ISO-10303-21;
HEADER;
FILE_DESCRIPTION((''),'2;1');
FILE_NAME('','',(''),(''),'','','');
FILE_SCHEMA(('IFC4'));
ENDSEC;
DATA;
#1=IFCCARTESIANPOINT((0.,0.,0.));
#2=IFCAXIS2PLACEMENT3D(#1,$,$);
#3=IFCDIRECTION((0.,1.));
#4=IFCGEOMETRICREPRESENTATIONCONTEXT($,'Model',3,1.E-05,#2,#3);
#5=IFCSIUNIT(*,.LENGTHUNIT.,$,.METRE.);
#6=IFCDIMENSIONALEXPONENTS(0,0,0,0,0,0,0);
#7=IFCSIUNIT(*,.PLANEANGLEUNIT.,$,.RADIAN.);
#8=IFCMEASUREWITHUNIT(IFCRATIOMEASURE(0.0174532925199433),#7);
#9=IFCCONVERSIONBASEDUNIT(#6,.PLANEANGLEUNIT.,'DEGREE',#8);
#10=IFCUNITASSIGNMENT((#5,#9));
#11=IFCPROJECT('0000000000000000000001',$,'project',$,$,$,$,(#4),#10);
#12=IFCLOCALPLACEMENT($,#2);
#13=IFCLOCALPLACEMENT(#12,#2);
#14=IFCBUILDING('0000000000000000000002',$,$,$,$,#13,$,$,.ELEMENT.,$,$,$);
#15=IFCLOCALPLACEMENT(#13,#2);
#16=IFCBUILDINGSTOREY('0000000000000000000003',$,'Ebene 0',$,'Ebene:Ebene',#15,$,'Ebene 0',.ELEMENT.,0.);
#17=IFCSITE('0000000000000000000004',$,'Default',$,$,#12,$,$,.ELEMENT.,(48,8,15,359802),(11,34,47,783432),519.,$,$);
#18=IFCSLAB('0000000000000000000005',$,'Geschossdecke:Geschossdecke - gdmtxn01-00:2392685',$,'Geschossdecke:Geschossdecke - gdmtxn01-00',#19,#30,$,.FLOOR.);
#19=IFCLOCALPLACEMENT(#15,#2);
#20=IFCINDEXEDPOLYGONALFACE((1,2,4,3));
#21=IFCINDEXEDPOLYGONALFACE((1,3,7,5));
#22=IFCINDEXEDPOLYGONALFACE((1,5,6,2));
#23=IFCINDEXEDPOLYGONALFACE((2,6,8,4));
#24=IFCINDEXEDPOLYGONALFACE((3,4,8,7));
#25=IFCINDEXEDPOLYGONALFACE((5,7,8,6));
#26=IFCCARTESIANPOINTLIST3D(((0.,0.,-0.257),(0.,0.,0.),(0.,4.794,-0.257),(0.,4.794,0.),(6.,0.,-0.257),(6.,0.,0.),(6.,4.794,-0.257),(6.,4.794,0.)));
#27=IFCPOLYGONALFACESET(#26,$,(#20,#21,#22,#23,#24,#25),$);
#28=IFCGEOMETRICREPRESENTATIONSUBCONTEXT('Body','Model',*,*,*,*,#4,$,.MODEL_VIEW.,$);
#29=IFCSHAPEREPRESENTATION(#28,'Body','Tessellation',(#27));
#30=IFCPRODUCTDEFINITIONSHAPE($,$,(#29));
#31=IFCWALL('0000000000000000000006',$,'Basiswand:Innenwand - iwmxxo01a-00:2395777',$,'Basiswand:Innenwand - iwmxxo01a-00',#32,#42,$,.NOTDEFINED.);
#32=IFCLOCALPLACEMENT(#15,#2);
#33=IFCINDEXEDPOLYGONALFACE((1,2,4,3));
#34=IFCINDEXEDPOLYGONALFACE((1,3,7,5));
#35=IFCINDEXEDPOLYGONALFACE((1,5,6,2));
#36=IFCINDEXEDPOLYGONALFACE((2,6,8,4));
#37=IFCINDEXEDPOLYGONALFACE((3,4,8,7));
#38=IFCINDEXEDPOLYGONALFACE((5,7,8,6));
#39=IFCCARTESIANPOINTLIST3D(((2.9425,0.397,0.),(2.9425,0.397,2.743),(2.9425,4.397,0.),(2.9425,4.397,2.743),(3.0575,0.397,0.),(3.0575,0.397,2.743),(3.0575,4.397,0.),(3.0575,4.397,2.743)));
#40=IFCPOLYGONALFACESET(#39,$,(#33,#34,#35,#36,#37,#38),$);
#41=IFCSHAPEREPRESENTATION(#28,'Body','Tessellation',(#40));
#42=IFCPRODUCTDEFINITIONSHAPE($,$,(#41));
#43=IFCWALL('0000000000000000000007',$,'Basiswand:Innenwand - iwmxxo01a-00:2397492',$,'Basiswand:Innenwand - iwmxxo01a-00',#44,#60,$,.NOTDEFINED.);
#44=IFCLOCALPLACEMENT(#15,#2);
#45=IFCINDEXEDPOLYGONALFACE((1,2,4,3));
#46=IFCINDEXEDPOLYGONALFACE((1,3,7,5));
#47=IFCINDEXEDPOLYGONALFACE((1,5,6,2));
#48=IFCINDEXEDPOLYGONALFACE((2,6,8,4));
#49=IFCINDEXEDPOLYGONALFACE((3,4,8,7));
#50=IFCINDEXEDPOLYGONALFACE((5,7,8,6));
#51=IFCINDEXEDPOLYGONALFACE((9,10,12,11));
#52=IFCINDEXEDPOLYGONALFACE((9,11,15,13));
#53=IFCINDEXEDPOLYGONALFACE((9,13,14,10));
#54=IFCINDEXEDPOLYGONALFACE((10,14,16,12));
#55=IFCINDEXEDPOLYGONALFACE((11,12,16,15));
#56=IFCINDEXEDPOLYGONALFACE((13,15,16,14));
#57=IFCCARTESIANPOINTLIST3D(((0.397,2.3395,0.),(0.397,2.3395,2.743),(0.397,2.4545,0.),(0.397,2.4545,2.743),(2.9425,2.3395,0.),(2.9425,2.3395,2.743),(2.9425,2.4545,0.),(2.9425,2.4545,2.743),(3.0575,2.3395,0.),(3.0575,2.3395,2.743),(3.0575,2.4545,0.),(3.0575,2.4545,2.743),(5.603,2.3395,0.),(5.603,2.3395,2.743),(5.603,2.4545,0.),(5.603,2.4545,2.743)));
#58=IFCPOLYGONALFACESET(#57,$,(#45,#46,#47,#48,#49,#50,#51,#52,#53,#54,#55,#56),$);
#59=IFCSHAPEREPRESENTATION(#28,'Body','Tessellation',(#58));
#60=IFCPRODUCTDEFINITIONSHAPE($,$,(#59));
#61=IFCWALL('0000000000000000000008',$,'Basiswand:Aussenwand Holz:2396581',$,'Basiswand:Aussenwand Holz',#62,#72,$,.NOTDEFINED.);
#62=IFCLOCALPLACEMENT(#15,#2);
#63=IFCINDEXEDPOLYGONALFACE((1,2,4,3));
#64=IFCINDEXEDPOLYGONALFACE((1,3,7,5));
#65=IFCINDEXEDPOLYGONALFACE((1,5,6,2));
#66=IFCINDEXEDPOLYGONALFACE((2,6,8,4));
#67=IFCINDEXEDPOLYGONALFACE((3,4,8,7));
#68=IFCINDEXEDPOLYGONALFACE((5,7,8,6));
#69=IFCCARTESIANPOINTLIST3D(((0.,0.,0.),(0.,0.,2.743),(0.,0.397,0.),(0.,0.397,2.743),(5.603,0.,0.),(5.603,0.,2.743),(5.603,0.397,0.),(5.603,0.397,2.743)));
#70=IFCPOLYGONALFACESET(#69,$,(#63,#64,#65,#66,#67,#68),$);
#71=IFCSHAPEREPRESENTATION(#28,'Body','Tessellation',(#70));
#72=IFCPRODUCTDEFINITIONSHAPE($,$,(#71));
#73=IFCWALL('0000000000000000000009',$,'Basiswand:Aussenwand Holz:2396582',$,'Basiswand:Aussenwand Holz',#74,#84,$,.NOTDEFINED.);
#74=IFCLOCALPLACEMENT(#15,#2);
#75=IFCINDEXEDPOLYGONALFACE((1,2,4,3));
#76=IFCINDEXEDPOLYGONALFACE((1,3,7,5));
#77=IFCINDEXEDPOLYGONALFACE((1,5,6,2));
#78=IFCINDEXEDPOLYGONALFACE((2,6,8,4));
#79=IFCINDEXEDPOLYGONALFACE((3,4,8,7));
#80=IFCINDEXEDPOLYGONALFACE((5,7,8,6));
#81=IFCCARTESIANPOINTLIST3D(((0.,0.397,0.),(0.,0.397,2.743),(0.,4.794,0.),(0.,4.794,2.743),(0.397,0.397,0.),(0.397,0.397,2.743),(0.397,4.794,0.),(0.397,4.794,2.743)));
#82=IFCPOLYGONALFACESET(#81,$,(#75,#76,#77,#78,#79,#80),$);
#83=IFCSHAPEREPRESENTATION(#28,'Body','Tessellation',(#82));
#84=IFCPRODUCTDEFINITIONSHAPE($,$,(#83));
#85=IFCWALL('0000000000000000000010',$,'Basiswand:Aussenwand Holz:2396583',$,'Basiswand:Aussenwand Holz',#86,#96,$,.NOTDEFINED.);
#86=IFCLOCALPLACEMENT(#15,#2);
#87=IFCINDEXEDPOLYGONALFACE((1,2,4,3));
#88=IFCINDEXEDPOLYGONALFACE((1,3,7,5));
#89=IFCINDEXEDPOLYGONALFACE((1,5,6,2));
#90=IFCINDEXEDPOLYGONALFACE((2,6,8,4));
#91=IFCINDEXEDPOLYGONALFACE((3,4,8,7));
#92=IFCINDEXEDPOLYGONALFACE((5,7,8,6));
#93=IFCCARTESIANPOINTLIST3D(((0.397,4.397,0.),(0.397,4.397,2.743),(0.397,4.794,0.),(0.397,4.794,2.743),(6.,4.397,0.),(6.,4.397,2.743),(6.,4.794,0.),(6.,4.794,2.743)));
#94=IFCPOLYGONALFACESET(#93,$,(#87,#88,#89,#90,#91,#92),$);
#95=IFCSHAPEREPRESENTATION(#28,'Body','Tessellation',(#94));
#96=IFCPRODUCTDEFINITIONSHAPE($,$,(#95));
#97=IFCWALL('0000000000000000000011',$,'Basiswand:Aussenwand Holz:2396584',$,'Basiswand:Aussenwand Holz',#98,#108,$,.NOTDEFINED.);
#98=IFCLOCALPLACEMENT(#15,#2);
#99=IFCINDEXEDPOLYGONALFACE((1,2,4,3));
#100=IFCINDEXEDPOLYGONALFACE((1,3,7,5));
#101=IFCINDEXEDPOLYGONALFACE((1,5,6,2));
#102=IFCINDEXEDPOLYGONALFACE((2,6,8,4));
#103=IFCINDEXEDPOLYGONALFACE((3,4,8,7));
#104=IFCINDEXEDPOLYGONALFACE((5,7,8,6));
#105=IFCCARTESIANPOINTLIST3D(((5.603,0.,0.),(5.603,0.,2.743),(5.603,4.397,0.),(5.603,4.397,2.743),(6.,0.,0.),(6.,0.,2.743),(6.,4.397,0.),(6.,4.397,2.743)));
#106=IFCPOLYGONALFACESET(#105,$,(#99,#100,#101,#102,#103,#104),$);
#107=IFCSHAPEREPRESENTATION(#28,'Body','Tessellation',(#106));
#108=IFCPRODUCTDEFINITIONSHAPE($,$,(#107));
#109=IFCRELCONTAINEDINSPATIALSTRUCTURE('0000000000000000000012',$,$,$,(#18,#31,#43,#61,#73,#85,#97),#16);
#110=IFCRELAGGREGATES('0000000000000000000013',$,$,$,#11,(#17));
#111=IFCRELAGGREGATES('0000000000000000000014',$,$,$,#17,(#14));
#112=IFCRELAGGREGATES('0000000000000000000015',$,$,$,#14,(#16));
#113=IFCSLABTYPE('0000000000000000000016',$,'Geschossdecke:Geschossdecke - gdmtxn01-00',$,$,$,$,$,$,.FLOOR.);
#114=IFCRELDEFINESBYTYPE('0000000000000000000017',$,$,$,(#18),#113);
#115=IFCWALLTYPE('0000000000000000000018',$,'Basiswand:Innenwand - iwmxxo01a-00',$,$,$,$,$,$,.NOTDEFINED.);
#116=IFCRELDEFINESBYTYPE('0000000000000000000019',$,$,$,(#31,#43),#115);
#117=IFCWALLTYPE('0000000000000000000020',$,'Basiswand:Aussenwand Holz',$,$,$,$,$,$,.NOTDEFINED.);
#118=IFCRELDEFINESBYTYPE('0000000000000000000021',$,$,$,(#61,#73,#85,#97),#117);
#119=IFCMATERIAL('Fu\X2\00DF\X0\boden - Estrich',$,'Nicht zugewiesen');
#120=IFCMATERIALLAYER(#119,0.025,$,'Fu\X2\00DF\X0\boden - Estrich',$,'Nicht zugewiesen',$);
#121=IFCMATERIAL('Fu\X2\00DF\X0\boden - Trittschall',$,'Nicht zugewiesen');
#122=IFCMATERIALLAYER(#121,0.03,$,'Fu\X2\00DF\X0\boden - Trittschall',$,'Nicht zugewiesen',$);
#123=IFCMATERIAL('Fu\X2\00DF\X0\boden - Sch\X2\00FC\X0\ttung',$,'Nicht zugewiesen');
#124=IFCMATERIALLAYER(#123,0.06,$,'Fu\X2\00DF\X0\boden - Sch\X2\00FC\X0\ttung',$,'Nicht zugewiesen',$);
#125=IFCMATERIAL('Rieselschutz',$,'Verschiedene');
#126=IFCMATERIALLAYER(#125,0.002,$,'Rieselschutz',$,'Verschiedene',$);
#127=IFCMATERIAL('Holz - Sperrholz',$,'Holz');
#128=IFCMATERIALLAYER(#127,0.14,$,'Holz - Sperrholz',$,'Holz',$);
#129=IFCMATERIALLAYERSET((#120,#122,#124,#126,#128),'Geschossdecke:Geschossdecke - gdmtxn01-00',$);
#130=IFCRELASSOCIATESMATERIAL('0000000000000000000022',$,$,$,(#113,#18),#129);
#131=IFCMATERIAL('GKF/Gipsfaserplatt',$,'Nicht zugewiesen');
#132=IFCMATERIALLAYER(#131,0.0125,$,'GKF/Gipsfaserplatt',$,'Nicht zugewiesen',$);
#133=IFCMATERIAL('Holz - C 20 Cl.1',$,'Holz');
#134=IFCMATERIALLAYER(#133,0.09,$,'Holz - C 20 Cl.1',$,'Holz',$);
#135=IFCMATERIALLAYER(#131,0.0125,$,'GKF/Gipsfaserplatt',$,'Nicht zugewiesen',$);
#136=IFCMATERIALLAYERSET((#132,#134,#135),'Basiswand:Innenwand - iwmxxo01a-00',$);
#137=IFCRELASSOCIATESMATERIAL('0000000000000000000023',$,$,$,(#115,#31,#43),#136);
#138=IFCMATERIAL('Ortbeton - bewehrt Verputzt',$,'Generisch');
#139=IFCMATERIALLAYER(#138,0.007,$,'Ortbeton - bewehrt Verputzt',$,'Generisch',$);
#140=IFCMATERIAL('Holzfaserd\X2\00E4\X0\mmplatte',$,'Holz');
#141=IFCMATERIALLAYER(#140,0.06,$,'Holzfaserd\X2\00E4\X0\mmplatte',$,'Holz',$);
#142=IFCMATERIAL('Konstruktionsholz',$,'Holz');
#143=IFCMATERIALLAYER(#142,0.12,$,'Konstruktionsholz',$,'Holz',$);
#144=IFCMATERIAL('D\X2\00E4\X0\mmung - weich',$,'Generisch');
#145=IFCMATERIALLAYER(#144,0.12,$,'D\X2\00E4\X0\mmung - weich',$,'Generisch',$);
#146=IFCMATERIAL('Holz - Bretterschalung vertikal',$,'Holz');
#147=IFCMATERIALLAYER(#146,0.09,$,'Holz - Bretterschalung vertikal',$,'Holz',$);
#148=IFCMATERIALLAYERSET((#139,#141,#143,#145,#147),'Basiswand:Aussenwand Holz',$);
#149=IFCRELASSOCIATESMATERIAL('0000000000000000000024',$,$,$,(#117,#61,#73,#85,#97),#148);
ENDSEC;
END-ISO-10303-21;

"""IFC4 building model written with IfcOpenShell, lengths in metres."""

from ifc_helpers import new_model, entity, si_unit, converted_unit, direction, frame, frame_2d, origin, place, context, subcontext, project, spatial, rectangle, extrude, material, layer, layer_set, layer_usage, type_object, element, save


model = new_model("IFC4")

# Units and contexts
model_context = context("Model", 3, precision=1e-05, world=origin(), true_north=direction((0.0, 1.0)))
body_context = subcontext(model_context, "Body", "Model", "MODEL_VIEW")
ifc_project = project(units=[si_unit("LENGTHUNIT", "METRE"), converted_unit("PLANEANGLEUNIT", "DEGREE", entity("IfcRatioMeasure", 0.0174532925199433), si_unit("PLANEANGLEUNIT", "RADIAN"), dimensions=[0, 0, 0, 0, 0, 0, 0])], contexts=[model_context])

# Site, building, storey
site_placement = place(None, frame((0.0, 0.0, 0.0)))
site = spatial("IfcSite", under=ifc_project, at=site_placement, Name="Default", CompositionType="ELEMENT", RefLatitude=(48, 8, 15, 359802), RefLongitude=(11, 34, 47, 783432), RefElevation=519.0)
building_placement = place(site_placement, origin())
building = spatial("IfcBuilding", under=site, at=building_placement, CompositionType="ELEMENT")
storey_placement = place(building_placement, origin())
storey = spatial("IfcBuildingStorey", under=building, at=storey_placement, Name="Ebene 0", ObjectType="Ebene:Ebene", LongName="Ebene 0", CompositionType="ELEMENT", Elevation=0.0)

# Slab
ifc_material_1 = material(Name="Fußboden - Estrich", Category="Nicht zugewiesen")
ifc_layer_1 = layer(ifc_material_1, 0.025, Name="Fußboden - Estrich", Category="Nicht zugewiesen")
ifc_material_2 = material(Name="Fußboden - Trittschall", Category="Nicht zugewiesen")
ifc_layer_2 = layer(ifc_material_2, 0.03, Name="Fußboden - Trittschall", Category="Nicht zugewiesen")
ifc_material_3 = material(Name="Fußboden - Schüttung", Category="Nicht zugewiesen")
ifc_layer_3 = layer(ifc_material_3, 0.06, Name="Fußboden - Schüttung", Category="Nicht zugewiesen")
ifc_material_4 = material(Name="Rieselschutz", Category="Verschiedene")
ifc_layer_4 = layer(ifc_material_4, 0.002, Name="Rieselschutz", Category="Verschiedene")
ifc_material_5 = material(Name="Holz - Sperrholz", Category="Holz")
ifc_layer_5 = layer(ifc_material_5, 0.14, Name="Holz - Sperrholz", Category="Holz")
ifc_layer_set_1 = layer_set([ifc_layer_1, ifc_layer_2, ifc_layer_3, ifc_layer_4, ifc_layer_5], Name="Geschossdecke:Geschossdecke - gdmtxn01-00")
ifc_layer_usage_1 = layer_usage(ifc_layer_set_1, "AXIS3", "POSITIVE", 0.0)
slab_type = type_object("IfcSlabType", Name="Geschossdecke:Geschossdecke - gdmtxn01-00", PredefinedType="FLOOR", material=ifc_layer_set_1)
slab_placement = place(storey_placement, origin())
element("IfcSlab", 1, at=slab_placement, inside=storey, type_object=slab_type, material=ifc_layer_usage_1, Name="Geschossdecke:Geschossdecke - gdmtxn01-00:2392685", ObjectType="Geschossdecke:Geschossdecke - gdmtxn01-00", PredefinedType="FLOOR", context=body_context, shape_type="SweptSolid", body=[
    extrude(rectangle(XDim=4.794, YDim=6.0, at=frame_2d((0.0, 0.0), x_axis=(1.0, 0.0))), frame((3.0, 2.397, 0.0), z_axis=(0.0, 0.0, -1.0), x_axis=(0.0, 1.0, 0.0)), (0.0, 0.0, 1.0), 0.257),
])

# Wall
ifc_material_6 = material(Name="GKF/Gipsfaserplatt", Category="Nicht zugewiesen")
ifc_layer_6 = layer(ifc_material_6, 0.0125, Name="GKF/Gipsfaserplatt", Category="Nicht zugewiesen")
ifc_material_7 = material(Name="Holz - C 20 Cl.1", Category="Holz")
ifc_layer_7 = layer(ifc_material_7, 0.09, Name="Holz - C 20 Cl.1", Category="Holz")
ifc_layer_8 = layer(ifc_material_6, 0.0125, Name="GKF/Gipsfaserplatt", Category="Nicht zugewiesen")
ifc_layer_set_2 = layer_set([ifc_layer_6, ifc_layer_7, ifc_layer_8], Name="Basiswand:Innenwand - iwmxxo01a-00")
ifc_layer_usage_2 = layer_usage(ifc_layer_set_2, "AXIS2", "NEGATIVE", 0.0575)
wall_type_1 = type_object("IfcWallType", Name="Basiswand:Innenwand - iwmxxo01a-00", PredefinedType="NOTDEFINED", material=ifc_layer_set_2)
wall_1_placement = place(storey_placement, frame((3.0, 0.397, 0.0), z_axis=(0.0, 0.0, 1.0), x_axis=(0.0, 1.0, 0.0)))
element("IfcWall", 2, at=wall_1_placement, inside=storey, type_object=wall_type_1, material=ifc_layer_usage_2, Name="Basiswand:Innenwand - iwmxxo01a-00:2395777", ObjectType="Basiswand:Innenwand - iwmxxo01a-00", PredefinedType="NOTDEFINED", context=body_context, shape_type="SweptSolid", body=[
    extrude(rectangle(XDim=4.0, YDim=0.115, at=frame_2d((2.0, 0.0), x_axis=(-1.0, 0.0))), origin(), (0.0, 0.0, 1.0), 2.743),
])

# Wall, opening
ifc_layer_usage_3 = layer_usage(ifc_layer_set_2, "AXIS2", "NEGATIVE", 0.0575)
wall_2_placement = place(storey_placement, frame((0.397, 2.397, 0.0)))
wall_2 = element("IfcWall", 3, at=wall_2_placement, inside=storey, type_object=wall_type_1, material=ifc_layer_usage_3, Name="Basiswand:Innenwand - iwmxxo01a-00:2397492", ObjectType="Basiswand:Innenwand - iwmxxo01a-00", PredefinedType="NOTDEFINED", context=body_context, shape_type="SweptSolid", body=[
    extrude(rectangle(XDim=5.206, YDim=0.115, at=frame_2d((2.603, 0.0), x_axis=(-1.0, 0.0))), origin(), (0.0, 0.0, 1.0), 2.743),
])
opening_placement = place(storey_placement, frame((0.397, 2.397, 0.0)))
element("IfcOpeningElement", 4, at=opening_placement, cuts=wall_2, ObjectType="Opening", PredefinedType="OPENING", context=body_context, shape_type="SweptSolid", body=[
    extrude(rectangle(XDim=2.743, YDim=0.115, at=frame_2d((0.0, 0.0), x_axis=(1.0, 0.0))), frame((2.5455, 0.0, 1.3715), z_axis=(1.0, 0.0, 0.0), x_axis=(0.0, 0.0, -1.0)), (0.0, 0.0, 1.0), 0.115),
])

# Walls
ifc_material_8 = material(Name="Ortbeton - bewehrt Verputzt", Category="Generisch")
ifc_layer_9 = layer(ifc_material_8, 0.007, Name="Ortbeton - bewehrt Verputzt", Category="Generisch")
ifc_material_9 = material(Name="Holzfaserdämmplatte", Category="Holz")
ifc_layer_10 = layer(ifc_material_9, 0.06, Name="Holzfaserdämmplatte", Category="Holz")
ifc_material_10 = material(Name="Konstruktionsholz", Category="Holz")
ifc_layer_11 = layer(ifc_material_10, 0.12, Name="Konstruktionsholz", Category="Holz")
ifc_material_11 = material(Name="Dämmung - weich", Category="Generisch")
ifc_layer_12 = layer(ifc_material_11, 0.12, Name="Dämmung - weich", Category="Generisch")
ifc_material_12 = material(Name="Holz - Bretterschalung vertikal", Category="Holz")
ifc_layer_13 = layer(ifc_material_12, 0.09, Name="Holz - Bretterschalung vertikal", Category="Holz")
ifc_layer_set_3 = layer_set([ifc_layer_9, ifc_layer_10, ifc_layer_11, ifc_layer_12, ifc_layer_13], Name="Basiswand:Aussenwand Holz")
ifc_layer_usage_4 = layer_usage(ifc_layer_set_3, "AXIS2", "NEGATIVE", 0.1985)
wall_type_2 = type_object("IfcWallType", Name="Basiswand:Aussenwand Holz", PredefinedType="NOTDEFINED", material=ifc_layer_set_3)
wall_3_placement = place(storey_placement, frame((0.0, 0.1985, 0.0)))
element("IfcWall", 5, at=wall_3_placement, inside=storey, type_object=wall_type_2, material=ifc_layer_usage_4, Name="Basiswand:Aussenwand Holz:2396581", ObjectType="Basiswand:Aussenwand Holz", PredefinedType="NOTDEFINED", context=body_context, shape_type="SweptSolid", body=[
    extrude(rectangle(XDim=5.603, YDim=0.397, at=frame_2d((2.8015, 0.0), x_axis=(-1.0, 0.0))), origin(), (0.0, 0.0, 1.0), 2.743),
])
ifc_layer_usage_5 = layer_usage(ifc_layer_set_3, "AXIS2", "NEGATIVE", 0.1985)
wall_4_placement = place(storey_placement, frame((0.1985, 4.794, 0.0), z_axis=(0.0, 0.0, 1.0), x_axis=(0.0, -1.0, 0.0)))
element("IfcWall", 6, at=wall_4_placement, inside=storey, type_object=wall_type_2, material=ifc_layer_usage_5, Name="Basiswand:Aussenwand Holz:2396582", ObjectType="Basiswand:Aussenwand Holz", PredefinedType="NOTDEFINED", context=body_context, shape_type="SweptSolid", body=[
    extrude(rectangle(XDim=4.397, YDim=0.397, at=frame_2d((2.1985, 0.0), x_axis=(-1.0, 0.0))), origin(), (0.0, 0.0, 1.0), 2.743),
])
ifc_layer_usage_6 = layer_usage(ifc_layer_set_3, "AXIS2", "NEGATIVE", 0.1985)
wall_5_placement = place(storey_placement, frame((6.0, 4.5955, 0.0), z_axis=(0.0, 0.0, 1.0), x_axis=(-1.0, 0.0, 0.0)))
element("IfcWall", 7, at=wall_5_placement, inside=storey, type_object=wall_type_2, material=ifc_layer_usage_6, Name="Basiswand:Aussenwand Holz:2396583", ObjectType="Basiswand:Aussenwand Holz", PredefinedType="NOTDEFINED", context=body_context, shape_type="SweptSolid", body=[
    extrude(rectangle(XDim=5.603, YDim=0.397, at=frame_2d((2.8015, 0.0), x_axis=(-1.0, 0.0))), origin(), (0.0, 0.0, 1.0), 2.743),
])
ifc_layer_usage_7 = layer_usage(ifc_layer_set_3, "AXIS2", "NEGATIVE", 0.1985)
wall_6_placement = place(storey_placement, frame((5.8015, 0.0, 0.0), z_axis=(0.0, 0.0, 1.0), x_axis=(0.0, 1.0, 0.0)))
element("IfcWall", 8, at=wall_6_placement, inside=storey, type_object=wall_type_2, material=ifc_layer_usage_7, Name="Basiswand:Aussenwand Holz:2396584", ObjectType="Basiswand:Aussenwand Holz", PredefinedType="NOTDEFINED", context=body_context, shape_type="SweptSolid", body=[
    extrude(rectangle(XDim=4.397, YDim=0.397, at=frame_2d((2.1985, 0.0), x_axis=(-1.0, 0.0))), origin(), (0.0, 0.0, 1.0), 2.743),
])

save(model, "model.ifc")
